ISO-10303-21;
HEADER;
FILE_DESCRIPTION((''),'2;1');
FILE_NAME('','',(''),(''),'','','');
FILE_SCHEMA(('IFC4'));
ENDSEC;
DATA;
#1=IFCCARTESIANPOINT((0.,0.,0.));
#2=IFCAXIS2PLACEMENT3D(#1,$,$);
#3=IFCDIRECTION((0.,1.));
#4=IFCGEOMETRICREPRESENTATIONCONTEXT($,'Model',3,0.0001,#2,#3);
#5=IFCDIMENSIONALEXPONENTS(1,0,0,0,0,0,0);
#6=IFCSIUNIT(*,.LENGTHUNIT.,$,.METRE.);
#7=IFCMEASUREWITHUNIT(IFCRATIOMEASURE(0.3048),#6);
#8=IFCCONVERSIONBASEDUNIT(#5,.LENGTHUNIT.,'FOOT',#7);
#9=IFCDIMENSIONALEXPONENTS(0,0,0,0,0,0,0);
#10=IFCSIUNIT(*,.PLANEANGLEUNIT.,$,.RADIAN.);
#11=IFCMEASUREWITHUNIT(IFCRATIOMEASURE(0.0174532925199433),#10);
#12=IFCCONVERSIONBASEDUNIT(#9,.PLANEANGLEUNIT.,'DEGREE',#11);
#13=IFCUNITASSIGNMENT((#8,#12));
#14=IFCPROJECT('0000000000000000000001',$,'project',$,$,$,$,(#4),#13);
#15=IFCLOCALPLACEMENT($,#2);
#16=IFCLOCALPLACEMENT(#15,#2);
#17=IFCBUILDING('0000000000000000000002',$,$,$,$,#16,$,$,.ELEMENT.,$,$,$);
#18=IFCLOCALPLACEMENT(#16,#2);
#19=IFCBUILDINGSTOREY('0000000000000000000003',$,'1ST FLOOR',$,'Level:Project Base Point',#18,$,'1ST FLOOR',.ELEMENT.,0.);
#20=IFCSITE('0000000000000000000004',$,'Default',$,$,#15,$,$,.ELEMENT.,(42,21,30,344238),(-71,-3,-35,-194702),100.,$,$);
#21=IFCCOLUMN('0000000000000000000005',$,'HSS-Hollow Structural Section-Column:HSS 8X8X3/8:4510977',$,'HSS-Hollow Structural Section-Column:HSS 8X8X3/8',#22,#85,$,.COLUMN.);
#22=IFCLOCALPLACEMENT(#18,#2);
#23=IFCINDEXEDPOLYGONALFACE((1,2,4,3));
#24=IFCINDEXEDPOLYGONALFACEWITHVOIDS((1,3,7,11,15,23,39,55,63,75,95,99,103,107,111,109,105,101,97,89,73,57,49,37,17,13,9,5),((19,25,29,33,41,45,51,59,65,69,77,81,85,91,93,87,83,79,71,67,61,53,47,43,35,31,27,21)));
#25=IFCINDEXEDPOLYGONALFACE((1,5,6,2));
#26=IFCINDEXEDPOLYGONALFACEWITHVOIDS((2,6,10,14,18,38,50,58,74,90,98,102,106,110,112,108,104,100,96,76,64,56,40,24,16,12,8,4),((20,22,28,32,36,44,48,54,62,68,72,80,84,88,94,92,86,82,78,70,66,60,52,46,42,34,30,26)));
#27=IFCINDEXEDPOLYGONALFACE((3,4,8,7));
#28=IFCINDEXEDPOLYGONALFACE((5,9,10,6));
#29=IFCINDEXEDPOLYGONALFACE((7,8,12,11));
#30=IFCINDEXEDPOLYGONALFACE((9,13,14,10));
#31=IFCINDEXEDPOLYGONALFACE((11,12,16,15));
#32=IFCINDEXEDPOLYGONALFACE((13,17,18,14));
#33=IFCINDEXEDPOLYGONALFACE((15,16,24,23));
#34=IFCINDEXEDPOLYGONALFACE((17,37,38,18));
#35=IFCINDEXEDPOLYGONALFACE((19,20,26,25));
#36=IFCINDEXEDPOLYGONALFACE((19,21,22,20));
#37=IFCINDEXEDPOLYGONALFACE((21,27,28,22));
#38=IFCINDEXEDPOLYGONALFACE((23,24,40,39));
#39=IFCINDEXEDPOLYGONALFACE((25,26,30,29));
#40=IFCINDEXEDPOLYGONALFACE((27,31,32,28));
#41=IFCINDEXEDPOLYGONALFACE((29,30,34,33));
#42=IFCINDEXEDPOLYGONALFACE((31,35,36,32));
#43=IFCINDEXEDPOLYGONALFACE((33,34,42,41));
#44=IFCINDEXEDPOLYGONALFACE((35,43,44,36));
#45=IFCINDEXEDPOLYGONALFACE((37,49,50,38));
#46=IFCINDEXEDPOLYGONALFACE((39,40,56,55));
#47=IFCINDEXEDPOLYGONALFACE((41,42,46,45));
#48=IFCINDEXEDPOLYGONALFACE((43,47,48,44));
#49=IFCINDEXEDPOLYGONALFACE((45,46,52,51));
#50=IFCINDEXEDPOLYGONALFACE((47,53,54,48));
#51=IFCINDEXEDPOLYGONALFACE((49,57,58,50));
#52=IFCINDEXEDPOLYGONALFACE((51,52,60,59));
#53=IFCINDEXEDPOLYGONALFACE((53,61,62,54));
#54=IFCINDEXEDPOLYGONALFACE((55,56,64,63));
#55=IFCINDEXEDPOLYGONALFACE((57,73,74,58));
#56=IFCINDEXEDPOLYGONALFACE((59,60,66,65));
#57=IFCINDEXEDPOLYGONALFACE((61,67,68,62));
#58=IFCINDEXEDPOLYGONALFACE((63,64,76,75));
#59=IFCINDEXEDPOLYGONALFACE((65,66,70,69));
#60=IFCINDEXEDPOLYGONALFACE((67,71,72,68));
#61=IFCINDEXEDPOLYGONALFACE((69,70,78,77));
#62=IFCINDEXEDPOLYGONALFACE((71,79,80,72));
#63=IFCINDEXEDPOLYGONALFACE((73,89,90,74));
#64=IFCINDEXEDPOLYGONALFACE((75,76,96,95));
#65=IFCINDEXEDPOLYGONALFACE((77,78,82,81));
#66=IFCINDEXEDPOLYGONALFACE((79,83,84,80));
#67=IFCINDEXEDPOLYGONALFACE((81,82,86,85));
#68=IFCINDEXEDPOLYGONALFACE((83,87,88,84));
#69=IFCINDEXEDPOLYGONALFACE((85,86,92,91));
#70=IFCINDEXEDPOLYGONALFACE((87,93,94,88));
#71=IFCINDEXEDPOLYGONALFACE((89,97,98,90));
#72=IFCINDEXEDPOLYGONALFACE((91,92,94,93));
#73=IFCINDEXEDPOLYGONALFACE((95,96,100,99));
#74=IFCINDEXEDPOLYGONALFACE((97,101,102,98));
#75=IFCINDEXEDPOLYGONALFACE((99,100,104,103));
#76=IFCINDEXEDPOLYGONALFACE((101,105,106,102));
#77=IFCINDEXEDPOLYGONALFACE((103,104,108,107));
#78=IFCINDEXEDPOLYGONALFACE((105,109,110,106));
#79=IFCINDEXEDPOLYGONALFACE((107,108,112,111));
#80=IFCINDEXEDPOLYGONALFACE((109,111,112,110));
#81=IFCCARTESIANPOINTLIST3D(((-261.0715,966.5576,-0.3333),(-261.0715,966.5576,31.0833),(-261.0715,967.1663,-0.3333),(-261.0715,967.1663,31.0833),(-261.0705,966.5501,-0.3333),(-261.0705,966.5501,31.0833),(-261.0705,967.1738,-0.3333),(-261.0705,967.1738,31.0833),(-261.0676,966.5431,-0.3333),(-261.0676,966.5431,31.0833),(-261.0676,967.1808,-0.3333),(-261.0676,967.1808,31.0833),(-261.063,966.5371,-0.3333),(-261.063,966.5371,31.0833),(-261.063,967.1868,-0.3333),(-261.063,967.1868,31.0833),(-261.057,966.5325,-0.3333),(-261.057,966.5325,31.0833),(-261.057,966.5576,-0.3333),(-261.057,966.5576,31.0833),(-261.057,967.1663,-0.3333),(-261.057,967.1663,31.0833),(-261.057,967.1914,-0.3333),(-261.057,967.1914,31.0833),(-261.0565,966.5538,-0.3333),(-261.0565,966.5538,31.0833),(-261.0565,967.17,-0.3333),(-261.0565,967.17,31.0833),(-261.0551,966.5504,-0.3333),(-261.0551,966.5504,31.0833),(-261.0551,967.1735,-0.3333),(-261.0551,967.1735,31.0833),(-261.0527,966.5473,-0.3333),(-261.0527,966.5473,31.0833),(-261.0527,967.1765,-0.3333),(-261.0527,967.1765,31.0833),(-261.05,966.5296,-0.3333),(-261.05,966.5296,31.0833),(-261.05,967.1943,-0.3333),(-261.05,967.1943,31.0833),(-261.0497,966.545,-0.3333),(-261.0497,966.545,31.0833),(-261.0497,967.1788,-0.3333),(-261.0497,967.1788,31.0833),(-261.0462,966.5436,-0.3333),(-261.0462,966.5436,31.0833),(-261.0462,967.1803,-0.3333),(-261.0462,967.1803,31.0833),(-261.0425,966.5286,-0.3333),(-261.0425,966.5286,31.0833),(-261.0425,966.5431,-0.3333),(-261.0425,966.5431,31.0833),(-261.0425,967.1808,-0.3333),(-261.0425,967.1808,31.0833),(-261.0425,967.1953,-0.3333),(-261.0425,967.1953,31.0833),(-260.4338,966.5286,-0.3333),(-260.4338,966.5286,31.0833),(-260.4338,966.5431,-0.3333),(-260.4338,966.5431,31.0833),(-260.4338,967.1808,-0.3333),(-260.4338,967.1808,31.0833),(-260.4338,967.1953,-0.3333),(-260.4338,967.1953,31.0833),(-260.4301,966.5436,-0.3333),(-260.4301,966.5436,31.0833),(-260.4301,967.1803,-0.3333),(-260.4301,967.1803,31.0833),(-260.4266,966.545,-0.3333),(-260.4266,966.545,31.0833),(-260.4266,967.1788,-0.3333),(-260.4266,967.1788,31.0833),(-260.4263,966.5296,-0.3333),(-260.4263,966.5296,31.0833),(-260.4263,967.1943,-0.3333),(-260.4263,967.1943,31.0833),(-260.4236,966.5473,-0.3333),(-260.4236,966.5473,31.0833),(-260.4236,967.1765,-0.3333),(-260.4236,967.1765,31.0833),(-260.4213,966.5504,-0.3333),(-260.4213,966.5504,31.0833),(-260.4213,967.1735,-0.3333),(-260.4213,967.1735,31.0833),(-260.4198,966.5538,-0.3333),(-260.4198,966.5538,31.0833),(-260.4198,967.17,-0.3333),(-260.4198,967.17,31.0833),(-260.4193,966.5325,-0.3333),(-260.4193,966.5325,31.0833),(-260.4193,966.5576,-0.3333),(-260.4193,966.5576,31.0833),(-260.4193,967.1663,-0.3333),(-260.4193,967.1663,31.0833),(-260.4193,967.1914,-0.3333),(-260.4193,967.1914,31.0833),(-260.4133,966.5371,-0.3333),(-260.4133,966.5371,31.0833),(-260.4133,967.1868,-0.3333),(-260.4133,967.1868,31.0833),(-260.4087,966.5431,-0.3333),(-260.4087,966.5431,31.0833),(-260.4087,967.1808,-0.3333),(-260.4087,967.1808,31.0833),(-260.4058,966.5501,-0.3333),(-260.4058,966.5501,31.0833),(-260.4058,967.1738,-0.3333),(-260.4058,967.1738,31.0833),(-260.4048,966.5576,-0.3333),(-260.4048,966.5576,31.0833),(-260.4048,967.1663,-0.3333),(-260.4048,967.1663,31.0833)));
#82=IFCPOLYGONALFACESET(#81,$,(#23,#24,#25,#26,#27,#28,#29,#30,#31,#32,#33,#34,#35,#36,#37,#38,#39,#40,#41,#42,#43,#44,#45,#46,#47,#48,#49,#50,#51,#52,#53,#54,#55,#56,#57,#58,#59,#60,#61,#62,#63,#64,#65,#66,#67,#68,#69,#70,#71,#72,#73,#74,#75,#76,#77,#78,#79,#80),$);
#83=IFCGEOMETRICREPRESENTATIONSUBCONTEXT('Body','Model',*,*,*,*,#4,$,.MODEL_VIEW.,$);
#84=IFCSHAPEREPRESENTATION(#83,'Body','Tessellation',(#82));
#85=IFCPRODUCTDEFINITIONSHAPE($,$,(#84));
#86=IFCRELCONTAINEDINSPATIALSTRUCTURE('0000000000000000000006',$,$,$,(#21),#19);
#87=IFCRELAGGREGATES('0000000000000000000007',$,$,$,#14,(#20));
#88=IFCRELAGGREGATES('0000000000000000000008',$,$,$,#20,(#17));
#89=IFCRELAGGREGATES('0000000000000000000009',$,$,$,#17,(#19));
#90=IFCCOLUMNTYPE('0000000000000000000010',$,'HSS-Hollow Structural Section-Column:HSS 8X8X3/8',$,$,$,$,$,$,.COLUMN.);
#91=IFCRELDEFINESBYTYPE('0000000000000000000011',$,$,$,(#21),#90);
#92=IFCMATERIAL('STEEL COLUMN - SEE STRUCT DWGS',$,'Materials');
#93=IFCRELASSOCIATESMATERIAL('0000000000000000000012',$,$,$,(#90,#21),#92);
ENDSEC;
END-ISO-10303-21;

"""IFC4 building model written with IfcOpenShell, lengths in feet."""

from ifc_helpers import new_model, entity, si_unit, converted_unit, direction, frame, frame_2d, origin, place, context, subcontext, project, spatial, polyline, circle_curve, parameter, trimmed, segment, composite_curve, outline, extrude, source, transform, mapped, material, material_profile, profile_set, profile_usage, type_object, type_shapes, element, save


model = new_model("IFC4")

# Units and contexts
model_context = context("Model", 3, precision=0.0001, world=origin(), true_north=direction((0.0, 1.0)))
body_context = subcontext(model_context, "Body", "Model", "MODEL_VIEW")
ifc_project = project(units=[converted_unit("LENGTHUNIT", "FOOT", entity("IfcRatioMeasure", 0.3048), si_unit("LENGTHUNIT", "METRE"), dimensions=[1, 0, 0, 0, 0, 0, 0]), converted_unit("PLANEANGLEUNIT", "DEGREE", entity("IfcRatioMeasure", 0.0174532925199433), si_unit("PLANEANGLEUNIT", "RADIAN"), dimensions=[0, 0, 0, 0, 0, 0, 0])], contexts=[model_context])

# Site, building, storey
site_placement = place(None, origin())
site = spatial("IfcSite", under=ifc_project, at=site_placement, Name="Default", CompositionType="ELEMENT", RefLatitude=(42, 21, 30, 344238), RefLongitude=(-71, -3, -35, -194702), RefElevation=100.0)
building_placement = place(site_placement, origin())
building = spatial("IfcBuilding", under=site, at=building_placement, CompositionType="ELEMENT")
storey_placement = place(building_placement, origin())
storey = spatial("IfcBuildingStorey", under=building, at=storey_placement, Name="1ST FLOOR", ObjectType="Level:Project Base Point", LongName="1ST FLOOR", CompositionType="ELEMENT", Elevation=0.0)

# Column
ifc_material_1 = material(Name="STEEL COLUMN - SEE STRUCT DWGS", Category="Materials")
ifc_material_profile_1 = material_profile(ifc_material_1, outline(composite_curve([segment(polyline([(-0.3043, -0.3333), (0.3043, -0.3333)]), True, "CONTINUOUS"), segment(trimmed(circle_curve(frame_2d((0.3043, -0.3043), x_axis=(-1.0, 0.0)), 0.029), [parameter(90.0)], [parameter(180.0)], True, "PARAMETER"), True, "CONTINUOUS"), segment(polyline([(0.3333, -0.3043), (0.3333, 0.3043)]), True, "CONTINUOUS"), segment(trimmed(circle_curve(frame_2d((0.3043, 0.3043), x_axis=(-1.0, 0.0)), 0.029), [parameter(180.0)], [parameter(270.0)], True, "PARAMETER"), True, "CONTINUOUS"), segment(polyline([(0.3043, 0.3333), (-0.3043, 0.3333)]), True, "CONTINUOUS"), segment(trimmed(circle_curve(frame_2d((-0.3043, 0.3043), x_axis=(-1.0, 0.0)), 0.029), [parameter(270.0)], [parameter(360.0)], True, "PARAMETER"), True, "CONTINUOUS"), segment(polyline([(-0.3333, 0.3043), (-0.3333, -0.3043)]), True, "CONTINUOUS"), segment(trimmed(circle_curve(frame_2d((-0.3043, -0.3043), x_axis=(-1.0, 0.0)), 0.029), [parameter(360.0)], [parameter(90.0)], True, "PARAMETER"), True, "CONTINUOUS")], self_intersect=False), holes=[composite_curve([segment(trimmed(circle_curve(frame_2d((-0.3043, -0.3043), x_axis=(-1.0, 0.0)), 0.0145), [parameter(0.0)], [parameter(90.0)], True, "PARAMETER"), False, "CONTINUOUS"), segment(polyline([(-0.3188, -0.3043), (-0.3188, 0.3043)]), True, "CONTINUOUS"), segment(trimmed(circle_curve(frame_2d((-0.3043, 0.3043), x_axis=(-1.0, 0.0)), 0.0145), [parameter(270.0)], [parameter(0.0)], True, "PARAMETER"), False, "CONTINUOUS"), segment(polyline([(-0.3043, 0.3188), (0.3043, 0.3188)]), True, "CONTINUOUS"), segment(trimmed(circle_curve(frame_2d((0.3043, 0.3043), x_axis=(-1.0, 0.0)), 0.0145), [parameter(180.0)], [parameter(270.0)], True, "PARAMETER"), False, "CONTINUOUS"), segment(polyline([(0.3188, 0.3043), (0.3188, -0.3043)]), True, "CONTINUOUS"), segment(trimmed(circle_curve(frame_2d((0.3043, -0.3043), x_axis=(-1.0, 0.0)), 0.0145), [parameter(90.0)], [parameter(180.0)], True, "PARAMETER"), False, "CONTINUOUS"), segment(polyline([(0.3043, -0.3188), (-0.3043, -0.3188)]), True, "CONTINUOUS")], self_intersect=False)]), Name="HSS 8X8X3/8")
ifc_profile_set_1 = profile_set([ifc_material_profile_1], Name="HSS 8X8X3/8")
ifc_profile_usage_1 = profile_usage(ifc_profile_set_1)
column_type_1 = type_object("IfcColumnType", Name="HSS-Hollow Structural Section-Column:HSS 8X8X3/8", PredefinedType="COLUMN", material=ifc_profile_set_1)
shared_shape_1 = source(origin(), body_context, "Body", "SweptSolid", [
    extrude(outline(composite_curve([segment(polyline([(-0.3043, -0.3333), (0.3043, -0.3333)]), True, "CONTINUOUS"), segment(trimmed(circle_curve(frame_2d((0.3043, -0.3043), x_axis=(-1.0, 0.0)), 0.029), [parameter(90.0)], [parameter(180.0)], True, "PARAMETER"), True, "CONTINUOUS"), segment(polyline([(0.3333, -0.3043), (0.3333, 0.3043)]), True, "CONTINUOUS"), segment(trimmed(circle_curve(frame_2d((0.3043, 0.3043), x_axis=(-1.0, 0.0)), 0.029), [parameter(180.0)], [parameter(270.0)], True, "PARAMETER"), True, "CONTINUOUS"), segment(polyline([(0.3043, 0.3333), (-0.3043, 0.3333)]), True, "CONTINUOUS"), segment(trimmed(circle_curve(frame_2d((-0.3043, 0.3043), x_axis=(-1.0, 0.0)), 0.029), [parameter(270.0)], [parameter(360.0)], True, "PARAMETER"), True, "CONTINUOUS"), segment(polyline([(-0.3333, 0.3043), (-0.3333, -0.3043)]), True, "CONTINUOUS"), segment(trimmed(circle_curve(frame_2d((-0.3043, -0.3043), x_axis=(-1.0, 0.0)), 0.029), [parameter(360.0)], [parameter(90.0)], True, "PARAMETER"), True, "CONTINUOUS")], self_intersect=False), holes=[composite_curve([segment(trimmed(circle_curve(frame_2d((-0.3043, -0.3043), x_axis=(-1.0, 0.0)), 0.0145), [parameter(0.0)], [parameter(90.0)], True, "PARAMETER"), False, "CONTINUOUS"), segment(polyline([(-0.3188, -0.3043), (-0.3188, 0.3043)]), True, "CONTINUOUS"), segment(trimmed(circle_curve(frame_2d((-0.3043, 0.3043), x_axis=(-1.0, 0.0)), 0.0145), [parameter(270.0)], [parameter(0.0)], True, "PARAMETER"), False, "CONTINUOUS"), segment(polyline([(-0.3043, 0.3188), (0.3043, 0.3188)]), True, "CONTINUOUS"), segment(trimmed(circle_curve(frame_2d((0.3043, 0.3043), x_axis=(-1.0, 0.0)), 0.0145), [parameter(180.0)], [parameter(270.0)], True, "PARAMETER"), False, "CONTINUOUS"), segment(polyline([(0.3188, 0.3043), (0.3188, -0.3043)]), True, "CONTINUOUS"), segment(trimmed(circle_curve(frame_2d((0.3043, -0.3043), x_axis=(-1.0, 0.0)), 0.0145), [parameter(90.0)], [parameter(180.0)], True, "PARAMETER"), False, "CONTINUOUS"), segment(polyline([(0.3043, -0.3188), (-0.3043, -0.3188)]), True, "CONTINUOUS")], self_intersect=False)]), frame((0.0, 0.0, -0.3333), z_axis=(0.0, 0.0, 1.0), x_axis=(-1.0, 0.0, 0.0)), (0.0, 0.0, 1.0), 31.4167),
])
type_shapes(column_type_1, [shared_shape_1])
column_1_placement = place(storey_placement, frame((-260.7382, 966.8619, 0.0)))
element("IfcColumn", 1, at=column_1_placement, inside=storey, type_object=column_type_1, material=ifc_profile_usage_1, Name="HSS-Hollow Structural Section-Column:HSS 8X8X3/8:4510977", ObjectType="HSS-Hollow Structural Section-Column:HSS 8X8X3/8", PredefinedType="COLUMN", context=body_context, shape_type="MappedRepresentation", body=[
    mapped(shared_shape_1, transform((0.0, 0.0, 0.0), scale=1.0)),
])

save(model, "model.ifc")
